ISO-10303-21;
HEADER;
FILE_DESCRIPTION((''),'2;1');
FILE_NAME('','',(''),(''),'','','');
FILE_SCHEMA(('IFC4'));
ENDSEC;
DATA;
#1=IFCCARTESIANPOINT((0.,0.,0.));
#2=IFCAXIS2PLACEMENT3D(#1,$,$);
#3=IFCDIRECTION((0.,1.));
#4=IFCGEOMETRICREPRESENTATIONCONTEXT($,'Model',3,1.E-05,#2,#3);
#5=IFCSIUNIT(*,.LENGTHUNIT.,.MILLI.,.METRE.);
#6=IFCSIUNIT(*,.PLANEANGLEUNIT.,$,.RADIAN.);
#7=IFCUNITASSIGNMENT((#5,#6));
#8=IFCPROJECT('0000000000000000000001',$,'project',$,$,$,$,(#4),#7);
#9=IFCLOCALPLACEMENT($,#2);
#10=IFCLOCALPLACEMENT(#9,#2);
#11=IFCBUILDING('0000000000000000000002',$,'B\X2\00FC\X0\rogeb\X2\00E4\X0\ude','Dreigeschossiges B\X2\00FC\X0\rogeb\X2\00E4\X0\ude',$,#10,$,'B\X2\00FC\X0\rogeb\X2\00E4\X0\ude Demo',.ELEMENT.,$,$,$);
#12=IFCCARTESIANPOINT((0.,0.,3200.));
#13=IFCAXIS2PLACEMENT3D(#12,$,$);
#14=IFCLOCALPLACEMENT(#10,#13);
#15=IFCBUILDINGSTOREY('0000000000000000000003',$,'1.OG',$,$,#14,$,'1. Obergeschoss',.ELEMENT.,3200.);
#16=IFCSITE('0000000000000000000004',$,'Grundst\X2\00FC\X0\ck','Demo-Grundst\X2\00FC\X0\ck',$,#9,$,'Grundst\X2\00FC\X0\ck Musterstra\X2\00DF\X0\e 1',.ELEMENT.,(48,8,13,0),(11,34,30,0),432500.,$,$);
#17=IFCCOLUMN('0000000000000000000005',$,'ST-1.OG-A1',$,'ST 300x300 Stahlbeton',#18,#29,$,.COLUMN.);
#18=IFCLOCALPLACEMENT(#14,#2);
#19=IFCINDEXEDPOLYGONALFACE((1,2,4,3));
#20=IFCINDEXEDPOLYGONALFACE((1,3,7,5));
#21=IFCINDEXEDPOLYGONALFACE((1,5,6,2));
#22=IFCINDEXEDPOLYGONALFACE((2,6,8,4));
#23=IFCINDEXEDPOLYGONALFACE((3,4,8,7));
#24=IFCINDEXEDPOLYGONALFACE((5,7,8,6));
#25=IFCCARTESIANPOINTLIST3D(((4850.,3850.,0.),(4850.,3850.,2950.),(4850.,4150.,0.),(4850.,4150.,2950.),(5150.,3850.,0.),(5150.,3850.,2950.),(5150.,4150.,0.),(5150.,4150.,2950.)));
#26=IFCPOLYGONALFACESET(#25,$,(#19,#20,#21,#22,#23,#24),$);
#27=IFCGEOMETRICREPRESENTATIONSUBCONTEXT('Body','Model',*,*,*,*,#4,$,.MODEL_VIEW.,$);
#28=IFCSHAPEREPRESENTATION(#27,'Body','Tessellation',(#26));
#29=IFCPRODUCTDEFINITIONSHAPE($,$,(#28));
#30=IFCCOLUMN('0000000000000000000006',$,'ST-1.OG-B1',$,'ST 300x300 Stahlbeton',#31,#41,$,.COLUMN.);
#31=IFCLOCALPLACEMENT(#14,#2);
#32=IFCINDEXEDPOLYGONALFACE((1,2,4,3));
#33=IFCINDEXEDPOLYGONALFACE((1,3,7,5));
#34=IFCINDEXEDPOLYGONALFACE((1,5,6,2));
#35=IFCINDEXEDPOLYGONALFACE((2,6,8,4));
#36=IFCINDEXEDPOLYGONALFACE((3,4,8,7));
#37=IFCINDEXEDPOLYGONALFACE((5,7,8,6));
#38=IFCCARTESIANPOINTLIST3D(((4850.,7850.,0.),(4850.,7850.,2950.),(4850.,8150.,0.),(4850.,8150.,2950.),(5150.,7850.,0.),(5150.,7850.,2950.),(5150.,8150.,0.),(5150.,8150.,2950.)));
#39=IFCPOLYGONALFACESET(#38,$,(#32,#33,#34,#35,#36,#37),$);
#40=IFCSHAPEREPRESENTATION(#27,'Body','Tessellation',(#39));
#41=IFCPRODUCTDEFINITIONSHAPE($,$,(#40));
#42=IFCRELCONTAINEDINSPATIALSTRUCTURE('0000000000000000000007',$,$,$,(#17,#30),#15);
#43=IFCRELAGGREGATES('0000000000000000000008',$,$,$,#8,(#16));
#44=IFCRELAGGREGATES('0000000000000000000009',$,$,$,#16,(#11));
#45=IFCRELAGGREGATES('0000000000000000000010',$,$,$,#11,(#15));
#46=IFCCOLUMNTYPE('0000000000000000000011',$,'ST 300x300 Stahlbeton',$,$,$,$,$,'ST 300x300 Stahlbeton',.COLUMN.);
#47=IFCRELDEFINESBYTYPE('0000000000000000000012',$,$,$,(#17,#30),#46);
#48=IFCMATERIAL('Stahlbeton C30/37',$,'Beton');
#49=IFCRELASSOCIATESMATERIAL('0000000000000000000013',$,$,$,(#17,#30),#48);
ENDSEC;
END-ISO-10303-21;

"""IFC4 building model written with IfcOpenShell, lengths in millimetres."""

from ifc_helpers import new_model, si_unit, direction, frame, origin, origin_2d, place, context, subcontext, project, spatial, rectangle, extrude, material, type_object, element, save


model = new_model("IFC4")

# Units and contexts
model_context = context("Model", 3, precision=1e-05, world=origin(), true_north=direction((0.0, 1.0)))
body_context = subcontext(model_context, "Body", "Model", "MODEL_VIEW")
ifc_project = project(units=[si_unit("LENGTHUNIT", "METRE", prefix="MILLI"), si_unit("PLANEANGLEUNIT", "RADIAN")], contexts=[model_context])

# Site, building, storey
site_placement = place(None, origin())
site = spatial("IfcSite", under=ifc_project, at=site_placement, Name="Grundstück", Description="Demo-Grundstück", LongName="Grundstück Musterstraße 1", CompositionType="ELEMENT", RefLatitude=(48, 8, 13, 0), RefLongitude=(11, 34, 30, 0), RefElevation=432500.0)
building_placement = place(site_placement, origin())
building = spatial("IfcBuilding", under=site, at=building_placement, Name="Bürogebäude", Description="Dreigeschossiges Bürogebäude", LongName="Bürogebäude Demo", CompositionType="ELEMENT")
storey_placement = place(building_placement, frame((0.0, 0.0, 3200.0)))
storey = spatial("IfcBuildingStorey", under=building, at=storey_placement, Name="1.OG", LongName="1. Obergeschoss", CompositionType="ELEMENT", Elevation=3200.0)

# Columns
ifc_material_1 = material(Name="Stahlbeton C30/37", Category="Beton")
column_type = type_object("IfcColumnType", Name="ST 300x300 Stahlbeton", ElementType="ST 300x300 Stahlbeton", PredefinedType="COLUMN")
for number, where, name in (
    (1, (5000.0, 4000.0, 0.0), "ST-1.OG-A1"),
    (2, (5000.0, 8000.0, 0.0), "ST-1.OG-B1"),
):
    element("IfcColumn", number, at=place(storey_placement, frame(where)), inside=storey, type_object=column_type, material=ifc_material_1, Name=name, ObjectType="ST 300x300 Stahlbeton", PredefinedType="COLUMN", context=body_context, shape_type="SweptSolid", body=[
        extrude(rectangle(XDim=300.0, YDim=300.0, at=origin_2d()), origin(), (0.0, 0.0, 1.0), 2950.0),
    ])

save(model, "model.ifc")
